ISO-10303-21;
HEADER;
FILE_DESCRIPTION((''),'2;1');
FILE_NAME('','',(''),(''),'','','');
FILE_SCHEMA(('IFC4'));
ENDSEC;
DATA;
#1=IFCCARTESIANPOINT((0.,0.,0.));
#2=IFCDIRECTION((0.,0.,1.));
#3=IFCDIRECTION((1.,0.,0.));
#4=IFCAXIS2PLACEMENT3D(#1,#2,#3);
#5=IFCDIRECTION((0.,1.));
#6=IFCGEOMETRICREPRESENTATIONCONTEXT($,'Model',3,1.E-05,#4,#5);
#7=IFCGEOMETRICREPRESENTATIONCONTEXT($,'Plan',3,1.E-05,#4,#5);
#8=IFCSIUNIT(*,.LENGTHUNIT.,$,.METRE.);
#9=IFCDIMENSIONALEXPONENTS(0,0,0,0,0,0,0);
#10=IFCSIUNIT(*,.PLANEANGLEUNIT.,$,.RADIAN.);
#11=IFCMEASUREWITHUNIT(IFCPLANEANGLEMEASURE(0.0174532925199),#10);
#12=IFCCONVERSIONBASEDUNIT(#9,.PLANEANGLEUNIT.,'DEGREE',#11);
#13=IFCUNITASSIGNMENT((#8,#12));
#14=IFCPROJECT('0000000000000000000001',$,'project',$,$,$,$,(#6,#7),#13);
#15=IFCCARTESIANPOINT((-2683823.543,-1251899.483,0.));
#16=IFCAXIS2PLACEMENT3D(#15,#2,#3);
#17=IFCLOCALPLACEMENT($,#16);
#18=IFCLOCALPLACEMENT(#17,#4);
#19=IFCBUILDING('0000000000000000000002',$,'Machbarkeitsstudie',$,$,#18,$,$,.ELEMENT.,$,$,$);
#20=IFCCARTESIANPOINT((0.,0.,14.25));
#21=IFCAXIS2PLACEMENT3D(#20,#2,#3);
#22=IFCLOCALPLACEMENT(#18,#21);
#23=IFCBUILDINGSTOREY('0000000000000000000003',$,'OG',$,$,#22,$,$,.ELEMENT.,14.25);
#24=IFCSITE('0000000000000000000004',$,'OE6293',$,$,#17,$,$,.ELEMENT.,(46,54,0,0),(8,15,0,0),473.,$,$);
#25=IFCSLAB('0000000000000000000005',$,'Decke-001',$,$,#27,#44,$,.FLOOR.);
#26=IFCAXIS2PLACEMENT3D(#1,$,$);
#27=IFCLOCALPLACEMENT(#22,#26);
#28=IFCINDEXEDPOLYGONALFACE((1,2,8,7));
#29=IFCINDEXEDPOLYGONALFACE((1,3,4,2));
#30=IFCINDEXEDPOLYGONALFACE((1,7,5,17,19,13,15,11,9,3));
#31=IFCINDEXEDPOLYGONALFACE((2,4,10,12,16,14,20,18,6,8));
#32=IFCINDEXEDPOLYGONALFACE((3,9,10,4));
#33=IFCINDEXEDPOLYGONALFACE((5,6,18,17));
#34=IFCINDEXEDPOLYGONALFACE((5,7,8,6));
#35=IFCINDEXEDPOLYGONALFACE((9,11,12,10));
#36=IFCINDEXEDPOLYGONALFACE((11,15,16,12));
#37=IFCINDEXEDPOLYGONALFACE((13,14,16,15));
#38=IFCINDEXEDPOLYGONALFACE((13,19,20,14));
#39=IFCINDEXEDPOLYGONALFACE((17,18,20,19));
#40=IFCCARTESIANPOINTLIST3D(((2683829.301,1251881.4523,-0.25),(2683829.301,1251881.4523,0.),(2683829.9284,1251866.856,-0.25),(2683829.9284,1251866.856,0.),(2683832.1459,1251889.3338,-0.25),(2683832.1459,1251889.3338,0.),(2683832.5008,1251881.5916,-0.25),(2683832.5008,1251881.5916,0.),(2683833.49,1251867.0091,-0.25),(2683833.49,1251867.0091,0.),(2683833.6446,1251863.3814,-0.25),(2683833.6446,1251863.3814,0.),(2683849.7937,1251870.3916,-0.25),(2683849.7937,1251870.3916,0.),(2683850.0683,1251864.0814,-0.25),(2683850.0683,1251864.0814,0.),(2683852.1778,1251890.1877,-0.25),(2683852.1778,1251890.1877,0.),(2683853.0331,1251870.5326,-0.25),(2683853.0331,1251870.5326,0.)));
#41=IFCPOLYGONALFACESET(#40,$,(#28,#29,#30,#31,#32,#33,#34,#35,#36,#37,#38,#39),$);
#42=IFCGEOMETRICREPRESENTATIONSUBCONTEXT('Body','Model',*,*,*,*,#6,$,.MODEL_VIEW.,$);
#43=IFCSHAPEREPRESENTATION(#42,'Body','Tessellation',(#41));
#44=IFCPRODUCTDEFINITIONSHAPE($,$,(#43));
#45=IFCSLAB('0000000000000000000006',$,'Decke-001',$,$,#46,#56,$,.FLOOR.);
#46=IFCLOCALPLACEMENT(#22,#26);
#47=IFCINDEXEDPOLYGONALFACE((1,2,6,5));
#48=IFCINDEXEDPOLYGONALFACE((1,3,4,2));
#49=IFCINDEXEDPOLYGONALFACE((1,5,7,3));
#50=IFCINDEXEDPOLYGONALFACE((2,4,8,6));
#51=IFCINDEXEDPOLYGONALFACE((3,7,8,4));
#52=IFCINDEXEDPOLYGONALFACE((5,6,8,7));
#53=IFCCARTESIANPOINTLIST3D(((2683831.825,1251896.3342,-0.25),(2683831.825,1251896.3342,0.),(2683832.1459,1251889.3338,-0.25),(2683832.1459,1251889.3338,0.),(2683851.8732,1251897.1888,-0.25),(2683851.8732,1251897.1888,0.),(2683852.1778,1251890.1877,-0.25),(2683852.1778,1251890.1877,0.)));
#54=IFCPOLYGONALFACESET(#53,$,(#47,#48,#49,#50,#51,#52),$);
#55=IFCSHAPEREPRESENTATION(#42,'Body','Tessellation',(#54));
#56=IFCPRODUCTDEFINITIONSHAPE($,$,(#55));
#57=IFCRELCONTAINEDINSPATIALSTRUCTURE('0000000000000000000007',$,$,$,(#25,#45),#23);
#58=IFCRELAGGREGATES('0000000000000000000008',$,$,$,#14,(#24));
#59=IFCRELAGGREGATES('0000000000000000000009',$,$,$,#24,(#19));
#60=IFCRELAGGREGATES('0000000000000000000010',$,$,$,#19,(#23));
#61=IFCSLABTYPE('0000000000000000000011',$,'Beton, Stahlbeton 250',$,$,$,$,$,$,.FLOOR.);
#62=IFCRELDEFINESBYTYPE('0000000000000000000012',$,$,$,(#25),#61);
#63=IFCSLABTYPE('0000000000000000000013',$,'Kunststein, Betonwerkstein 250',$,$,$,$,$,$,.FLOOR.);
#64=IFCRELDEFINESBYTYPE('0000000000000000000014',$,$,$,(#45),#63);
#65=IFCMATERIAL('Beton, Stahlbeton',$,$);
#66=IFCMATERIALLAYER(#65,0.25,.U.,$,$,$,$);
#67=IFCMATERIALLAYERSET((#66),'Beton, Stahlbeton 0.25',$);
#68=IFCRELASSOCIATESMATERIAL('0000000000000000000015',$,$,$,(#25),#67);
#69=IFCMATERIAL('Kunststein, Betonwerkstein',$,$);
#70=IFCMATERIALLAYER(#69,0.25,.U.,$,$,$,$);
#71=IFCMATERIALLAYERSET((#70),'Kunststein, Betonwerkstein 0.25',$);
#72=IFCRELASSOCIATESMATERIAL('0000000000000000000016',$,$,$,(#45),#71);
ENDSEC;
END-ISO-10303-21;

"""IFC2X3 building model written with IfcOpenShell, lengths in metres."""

from ifc_helpers import new_model, entity, si_unit, converted_unit, direction, frame, origin_with_axes, place, context, subcontext, project, spatial, polyline, outline, extrude, material, layer, layer_set, layer_usage, type_object, element, save


model = new_model("IFC2X3")

# Units and contexts
model_context = context("Model", 3, precision=1e-05, world=origin_with_axes(), true_north=direction((0.0, 1.0)))
plan_context = context("Plan", 3, precision=1e-05, world=origin_with_axes(), true_north=direction((0.0, 1.0)))
body_context = subcontext(model_context, "Body", "Model", "MODEL_VIEW")
ifc_project = project(units=[si_unit("LENGTHUNIT", "METRE"), converted_unit("PLANEANGLEUNIT", "DEGREE", entity("IfcPlaneAngleMeasure", 0.0174532925199), si_unit("PLANEANGLEUNIT", "RADIAN"), dimensions=[0, 0, 0, 0, 0, 0, 0])], contexts=[model_context, plan_context])

# Site, building, storey
site_placement = place(None, frame((-2683823.543, -1251899.483, 0.0), z_axis=(0.0, 0.0, 1.0), x_axis=(1.0, 0.0, 0.0)))
site = spatial("IfcSite", under=ifc_project, at=site_placement, Name="OE6293", CompositionType="ELEMENT", RefLatitude=(46, 54, 0, 0), RefLongitude=(8, 15, 0, 0), RefElevation=473.0)
building_placement = place(site_placement, origin_with_axes())
building = spatial("IfcBuilding", under=site, at=building_placement, Name="Machbarkeitsstudie", CompositionType="ELEMENT")
storey_placement = place(building_placement, frame((0.0, 0.0, 14.25), z_axis=(0.0, 0.0, 1.0), x_axis=(1.0, 0.0, 0.0)))
storey = spatial("IfcBuildingStorey", under=building, at=storey_placement, Name="OG", CompositionType="ELEMENT", Elevation=14.25)

# Slabs
ifc_material_1 = material(Name="Beton, Stahlbeton")
ifc_layer_1 = layer(ifc_material_1, 0.25, ventilated="UNKNOWN")
ifc_layer_set_1 = layer_set([ifc_layer_1], Name="Beton, Stahlbeton 0.25")
ifc_layer_usage_1 = layer_usage(ifc_layer_set_1, "AXIS3", "NEGATIVE", 0.25)
slab_type_1 = type_object("IfcSlabType", Name="Beton, Stahlbeton 250", PredefinedType="FLOOR")
slab_1_placement = place(storey_placement, frame((2683832.5008, 1251881.5916, 0.0), z_axis=(0.0, 0.0, 1.0), x_axis=(1.0, 0.0, 0.0)))
element("IfcSlab", 1, at=slab_1_placement, inside=storey, type_object=slab_type_1, material=ifc_layer_usage_1, Name="Decke-001", PredefinedType="FLOOR", context=body_context, shape_type="SweptSolid", body=[
    extrude(outline(polyline([(0.0, 0.0), (-3.1998, -0.1392), (-2.5724, -14.7356), (0.9892, -14.5825), (1.1438, -18.2102), (17.5674, -17.5102), (17.2928, -11.2), (20.5323, -11.059), (19.677, 8.5961), (-0.3549, 7.7422), (0.0, 0.0)])), frame((0.0, 0.0, -0.25), z_axis=(0.0, 0.0, 1.0), x_axis=(1.0, 0.0, 0.0)), (0.0, 0.0, 1.0), 0.25),
])
ifc_material_2 = material(Name="Kunststein, Betonwerkstein")
ifc_layer_2 = layer(ifc_material_2, 0.25, ventilated="UNKNOWN")
ifc_layer_set_2 = layer_set([ifc_layer_2], Name="Kunststein, Betonwerkstein 0.25")
ifc_layer_usage_2 = layer_usage(ifc_layer_set_2, "AXIS3", "NEGATIVE", 0.25)
slab_type_2 = type_object("IfcSlabType", Name="Kunststein, Betonwerkstein 250", PredefinedType="FLOOR")
slab_2_placement = place(storey_placement, frame((2683831.825, 1251896.3342, 0.0), z_axis=(0.0, 0.0, 1.0), x_axis=(1.0, 0.0, 0.0)))
element("IfcSlab", 2, at=slab_2_placement, inside=storey, type_object=slab_type_2, material=ifc_layer_usage_2, Name="Decke-001", PredefinedType="FLOOR", context=body_context, shape_type="SweptSolid", body=[
    extrude(outline(polyline([(0.0, 0.0), (0.3209, -7.0004), (20.3528, -6.1465), (20.0481, 0.8546), (0.0, 0.0)])), frame((0.0, 0.0, -0.25), z_axis=(0.0, 0.0, 1.0), x_axis=(1.0, 0.0, 0.0)), (0.0, 0.0, 1.0), 0.25),
])

save(model, "model.ifc")
